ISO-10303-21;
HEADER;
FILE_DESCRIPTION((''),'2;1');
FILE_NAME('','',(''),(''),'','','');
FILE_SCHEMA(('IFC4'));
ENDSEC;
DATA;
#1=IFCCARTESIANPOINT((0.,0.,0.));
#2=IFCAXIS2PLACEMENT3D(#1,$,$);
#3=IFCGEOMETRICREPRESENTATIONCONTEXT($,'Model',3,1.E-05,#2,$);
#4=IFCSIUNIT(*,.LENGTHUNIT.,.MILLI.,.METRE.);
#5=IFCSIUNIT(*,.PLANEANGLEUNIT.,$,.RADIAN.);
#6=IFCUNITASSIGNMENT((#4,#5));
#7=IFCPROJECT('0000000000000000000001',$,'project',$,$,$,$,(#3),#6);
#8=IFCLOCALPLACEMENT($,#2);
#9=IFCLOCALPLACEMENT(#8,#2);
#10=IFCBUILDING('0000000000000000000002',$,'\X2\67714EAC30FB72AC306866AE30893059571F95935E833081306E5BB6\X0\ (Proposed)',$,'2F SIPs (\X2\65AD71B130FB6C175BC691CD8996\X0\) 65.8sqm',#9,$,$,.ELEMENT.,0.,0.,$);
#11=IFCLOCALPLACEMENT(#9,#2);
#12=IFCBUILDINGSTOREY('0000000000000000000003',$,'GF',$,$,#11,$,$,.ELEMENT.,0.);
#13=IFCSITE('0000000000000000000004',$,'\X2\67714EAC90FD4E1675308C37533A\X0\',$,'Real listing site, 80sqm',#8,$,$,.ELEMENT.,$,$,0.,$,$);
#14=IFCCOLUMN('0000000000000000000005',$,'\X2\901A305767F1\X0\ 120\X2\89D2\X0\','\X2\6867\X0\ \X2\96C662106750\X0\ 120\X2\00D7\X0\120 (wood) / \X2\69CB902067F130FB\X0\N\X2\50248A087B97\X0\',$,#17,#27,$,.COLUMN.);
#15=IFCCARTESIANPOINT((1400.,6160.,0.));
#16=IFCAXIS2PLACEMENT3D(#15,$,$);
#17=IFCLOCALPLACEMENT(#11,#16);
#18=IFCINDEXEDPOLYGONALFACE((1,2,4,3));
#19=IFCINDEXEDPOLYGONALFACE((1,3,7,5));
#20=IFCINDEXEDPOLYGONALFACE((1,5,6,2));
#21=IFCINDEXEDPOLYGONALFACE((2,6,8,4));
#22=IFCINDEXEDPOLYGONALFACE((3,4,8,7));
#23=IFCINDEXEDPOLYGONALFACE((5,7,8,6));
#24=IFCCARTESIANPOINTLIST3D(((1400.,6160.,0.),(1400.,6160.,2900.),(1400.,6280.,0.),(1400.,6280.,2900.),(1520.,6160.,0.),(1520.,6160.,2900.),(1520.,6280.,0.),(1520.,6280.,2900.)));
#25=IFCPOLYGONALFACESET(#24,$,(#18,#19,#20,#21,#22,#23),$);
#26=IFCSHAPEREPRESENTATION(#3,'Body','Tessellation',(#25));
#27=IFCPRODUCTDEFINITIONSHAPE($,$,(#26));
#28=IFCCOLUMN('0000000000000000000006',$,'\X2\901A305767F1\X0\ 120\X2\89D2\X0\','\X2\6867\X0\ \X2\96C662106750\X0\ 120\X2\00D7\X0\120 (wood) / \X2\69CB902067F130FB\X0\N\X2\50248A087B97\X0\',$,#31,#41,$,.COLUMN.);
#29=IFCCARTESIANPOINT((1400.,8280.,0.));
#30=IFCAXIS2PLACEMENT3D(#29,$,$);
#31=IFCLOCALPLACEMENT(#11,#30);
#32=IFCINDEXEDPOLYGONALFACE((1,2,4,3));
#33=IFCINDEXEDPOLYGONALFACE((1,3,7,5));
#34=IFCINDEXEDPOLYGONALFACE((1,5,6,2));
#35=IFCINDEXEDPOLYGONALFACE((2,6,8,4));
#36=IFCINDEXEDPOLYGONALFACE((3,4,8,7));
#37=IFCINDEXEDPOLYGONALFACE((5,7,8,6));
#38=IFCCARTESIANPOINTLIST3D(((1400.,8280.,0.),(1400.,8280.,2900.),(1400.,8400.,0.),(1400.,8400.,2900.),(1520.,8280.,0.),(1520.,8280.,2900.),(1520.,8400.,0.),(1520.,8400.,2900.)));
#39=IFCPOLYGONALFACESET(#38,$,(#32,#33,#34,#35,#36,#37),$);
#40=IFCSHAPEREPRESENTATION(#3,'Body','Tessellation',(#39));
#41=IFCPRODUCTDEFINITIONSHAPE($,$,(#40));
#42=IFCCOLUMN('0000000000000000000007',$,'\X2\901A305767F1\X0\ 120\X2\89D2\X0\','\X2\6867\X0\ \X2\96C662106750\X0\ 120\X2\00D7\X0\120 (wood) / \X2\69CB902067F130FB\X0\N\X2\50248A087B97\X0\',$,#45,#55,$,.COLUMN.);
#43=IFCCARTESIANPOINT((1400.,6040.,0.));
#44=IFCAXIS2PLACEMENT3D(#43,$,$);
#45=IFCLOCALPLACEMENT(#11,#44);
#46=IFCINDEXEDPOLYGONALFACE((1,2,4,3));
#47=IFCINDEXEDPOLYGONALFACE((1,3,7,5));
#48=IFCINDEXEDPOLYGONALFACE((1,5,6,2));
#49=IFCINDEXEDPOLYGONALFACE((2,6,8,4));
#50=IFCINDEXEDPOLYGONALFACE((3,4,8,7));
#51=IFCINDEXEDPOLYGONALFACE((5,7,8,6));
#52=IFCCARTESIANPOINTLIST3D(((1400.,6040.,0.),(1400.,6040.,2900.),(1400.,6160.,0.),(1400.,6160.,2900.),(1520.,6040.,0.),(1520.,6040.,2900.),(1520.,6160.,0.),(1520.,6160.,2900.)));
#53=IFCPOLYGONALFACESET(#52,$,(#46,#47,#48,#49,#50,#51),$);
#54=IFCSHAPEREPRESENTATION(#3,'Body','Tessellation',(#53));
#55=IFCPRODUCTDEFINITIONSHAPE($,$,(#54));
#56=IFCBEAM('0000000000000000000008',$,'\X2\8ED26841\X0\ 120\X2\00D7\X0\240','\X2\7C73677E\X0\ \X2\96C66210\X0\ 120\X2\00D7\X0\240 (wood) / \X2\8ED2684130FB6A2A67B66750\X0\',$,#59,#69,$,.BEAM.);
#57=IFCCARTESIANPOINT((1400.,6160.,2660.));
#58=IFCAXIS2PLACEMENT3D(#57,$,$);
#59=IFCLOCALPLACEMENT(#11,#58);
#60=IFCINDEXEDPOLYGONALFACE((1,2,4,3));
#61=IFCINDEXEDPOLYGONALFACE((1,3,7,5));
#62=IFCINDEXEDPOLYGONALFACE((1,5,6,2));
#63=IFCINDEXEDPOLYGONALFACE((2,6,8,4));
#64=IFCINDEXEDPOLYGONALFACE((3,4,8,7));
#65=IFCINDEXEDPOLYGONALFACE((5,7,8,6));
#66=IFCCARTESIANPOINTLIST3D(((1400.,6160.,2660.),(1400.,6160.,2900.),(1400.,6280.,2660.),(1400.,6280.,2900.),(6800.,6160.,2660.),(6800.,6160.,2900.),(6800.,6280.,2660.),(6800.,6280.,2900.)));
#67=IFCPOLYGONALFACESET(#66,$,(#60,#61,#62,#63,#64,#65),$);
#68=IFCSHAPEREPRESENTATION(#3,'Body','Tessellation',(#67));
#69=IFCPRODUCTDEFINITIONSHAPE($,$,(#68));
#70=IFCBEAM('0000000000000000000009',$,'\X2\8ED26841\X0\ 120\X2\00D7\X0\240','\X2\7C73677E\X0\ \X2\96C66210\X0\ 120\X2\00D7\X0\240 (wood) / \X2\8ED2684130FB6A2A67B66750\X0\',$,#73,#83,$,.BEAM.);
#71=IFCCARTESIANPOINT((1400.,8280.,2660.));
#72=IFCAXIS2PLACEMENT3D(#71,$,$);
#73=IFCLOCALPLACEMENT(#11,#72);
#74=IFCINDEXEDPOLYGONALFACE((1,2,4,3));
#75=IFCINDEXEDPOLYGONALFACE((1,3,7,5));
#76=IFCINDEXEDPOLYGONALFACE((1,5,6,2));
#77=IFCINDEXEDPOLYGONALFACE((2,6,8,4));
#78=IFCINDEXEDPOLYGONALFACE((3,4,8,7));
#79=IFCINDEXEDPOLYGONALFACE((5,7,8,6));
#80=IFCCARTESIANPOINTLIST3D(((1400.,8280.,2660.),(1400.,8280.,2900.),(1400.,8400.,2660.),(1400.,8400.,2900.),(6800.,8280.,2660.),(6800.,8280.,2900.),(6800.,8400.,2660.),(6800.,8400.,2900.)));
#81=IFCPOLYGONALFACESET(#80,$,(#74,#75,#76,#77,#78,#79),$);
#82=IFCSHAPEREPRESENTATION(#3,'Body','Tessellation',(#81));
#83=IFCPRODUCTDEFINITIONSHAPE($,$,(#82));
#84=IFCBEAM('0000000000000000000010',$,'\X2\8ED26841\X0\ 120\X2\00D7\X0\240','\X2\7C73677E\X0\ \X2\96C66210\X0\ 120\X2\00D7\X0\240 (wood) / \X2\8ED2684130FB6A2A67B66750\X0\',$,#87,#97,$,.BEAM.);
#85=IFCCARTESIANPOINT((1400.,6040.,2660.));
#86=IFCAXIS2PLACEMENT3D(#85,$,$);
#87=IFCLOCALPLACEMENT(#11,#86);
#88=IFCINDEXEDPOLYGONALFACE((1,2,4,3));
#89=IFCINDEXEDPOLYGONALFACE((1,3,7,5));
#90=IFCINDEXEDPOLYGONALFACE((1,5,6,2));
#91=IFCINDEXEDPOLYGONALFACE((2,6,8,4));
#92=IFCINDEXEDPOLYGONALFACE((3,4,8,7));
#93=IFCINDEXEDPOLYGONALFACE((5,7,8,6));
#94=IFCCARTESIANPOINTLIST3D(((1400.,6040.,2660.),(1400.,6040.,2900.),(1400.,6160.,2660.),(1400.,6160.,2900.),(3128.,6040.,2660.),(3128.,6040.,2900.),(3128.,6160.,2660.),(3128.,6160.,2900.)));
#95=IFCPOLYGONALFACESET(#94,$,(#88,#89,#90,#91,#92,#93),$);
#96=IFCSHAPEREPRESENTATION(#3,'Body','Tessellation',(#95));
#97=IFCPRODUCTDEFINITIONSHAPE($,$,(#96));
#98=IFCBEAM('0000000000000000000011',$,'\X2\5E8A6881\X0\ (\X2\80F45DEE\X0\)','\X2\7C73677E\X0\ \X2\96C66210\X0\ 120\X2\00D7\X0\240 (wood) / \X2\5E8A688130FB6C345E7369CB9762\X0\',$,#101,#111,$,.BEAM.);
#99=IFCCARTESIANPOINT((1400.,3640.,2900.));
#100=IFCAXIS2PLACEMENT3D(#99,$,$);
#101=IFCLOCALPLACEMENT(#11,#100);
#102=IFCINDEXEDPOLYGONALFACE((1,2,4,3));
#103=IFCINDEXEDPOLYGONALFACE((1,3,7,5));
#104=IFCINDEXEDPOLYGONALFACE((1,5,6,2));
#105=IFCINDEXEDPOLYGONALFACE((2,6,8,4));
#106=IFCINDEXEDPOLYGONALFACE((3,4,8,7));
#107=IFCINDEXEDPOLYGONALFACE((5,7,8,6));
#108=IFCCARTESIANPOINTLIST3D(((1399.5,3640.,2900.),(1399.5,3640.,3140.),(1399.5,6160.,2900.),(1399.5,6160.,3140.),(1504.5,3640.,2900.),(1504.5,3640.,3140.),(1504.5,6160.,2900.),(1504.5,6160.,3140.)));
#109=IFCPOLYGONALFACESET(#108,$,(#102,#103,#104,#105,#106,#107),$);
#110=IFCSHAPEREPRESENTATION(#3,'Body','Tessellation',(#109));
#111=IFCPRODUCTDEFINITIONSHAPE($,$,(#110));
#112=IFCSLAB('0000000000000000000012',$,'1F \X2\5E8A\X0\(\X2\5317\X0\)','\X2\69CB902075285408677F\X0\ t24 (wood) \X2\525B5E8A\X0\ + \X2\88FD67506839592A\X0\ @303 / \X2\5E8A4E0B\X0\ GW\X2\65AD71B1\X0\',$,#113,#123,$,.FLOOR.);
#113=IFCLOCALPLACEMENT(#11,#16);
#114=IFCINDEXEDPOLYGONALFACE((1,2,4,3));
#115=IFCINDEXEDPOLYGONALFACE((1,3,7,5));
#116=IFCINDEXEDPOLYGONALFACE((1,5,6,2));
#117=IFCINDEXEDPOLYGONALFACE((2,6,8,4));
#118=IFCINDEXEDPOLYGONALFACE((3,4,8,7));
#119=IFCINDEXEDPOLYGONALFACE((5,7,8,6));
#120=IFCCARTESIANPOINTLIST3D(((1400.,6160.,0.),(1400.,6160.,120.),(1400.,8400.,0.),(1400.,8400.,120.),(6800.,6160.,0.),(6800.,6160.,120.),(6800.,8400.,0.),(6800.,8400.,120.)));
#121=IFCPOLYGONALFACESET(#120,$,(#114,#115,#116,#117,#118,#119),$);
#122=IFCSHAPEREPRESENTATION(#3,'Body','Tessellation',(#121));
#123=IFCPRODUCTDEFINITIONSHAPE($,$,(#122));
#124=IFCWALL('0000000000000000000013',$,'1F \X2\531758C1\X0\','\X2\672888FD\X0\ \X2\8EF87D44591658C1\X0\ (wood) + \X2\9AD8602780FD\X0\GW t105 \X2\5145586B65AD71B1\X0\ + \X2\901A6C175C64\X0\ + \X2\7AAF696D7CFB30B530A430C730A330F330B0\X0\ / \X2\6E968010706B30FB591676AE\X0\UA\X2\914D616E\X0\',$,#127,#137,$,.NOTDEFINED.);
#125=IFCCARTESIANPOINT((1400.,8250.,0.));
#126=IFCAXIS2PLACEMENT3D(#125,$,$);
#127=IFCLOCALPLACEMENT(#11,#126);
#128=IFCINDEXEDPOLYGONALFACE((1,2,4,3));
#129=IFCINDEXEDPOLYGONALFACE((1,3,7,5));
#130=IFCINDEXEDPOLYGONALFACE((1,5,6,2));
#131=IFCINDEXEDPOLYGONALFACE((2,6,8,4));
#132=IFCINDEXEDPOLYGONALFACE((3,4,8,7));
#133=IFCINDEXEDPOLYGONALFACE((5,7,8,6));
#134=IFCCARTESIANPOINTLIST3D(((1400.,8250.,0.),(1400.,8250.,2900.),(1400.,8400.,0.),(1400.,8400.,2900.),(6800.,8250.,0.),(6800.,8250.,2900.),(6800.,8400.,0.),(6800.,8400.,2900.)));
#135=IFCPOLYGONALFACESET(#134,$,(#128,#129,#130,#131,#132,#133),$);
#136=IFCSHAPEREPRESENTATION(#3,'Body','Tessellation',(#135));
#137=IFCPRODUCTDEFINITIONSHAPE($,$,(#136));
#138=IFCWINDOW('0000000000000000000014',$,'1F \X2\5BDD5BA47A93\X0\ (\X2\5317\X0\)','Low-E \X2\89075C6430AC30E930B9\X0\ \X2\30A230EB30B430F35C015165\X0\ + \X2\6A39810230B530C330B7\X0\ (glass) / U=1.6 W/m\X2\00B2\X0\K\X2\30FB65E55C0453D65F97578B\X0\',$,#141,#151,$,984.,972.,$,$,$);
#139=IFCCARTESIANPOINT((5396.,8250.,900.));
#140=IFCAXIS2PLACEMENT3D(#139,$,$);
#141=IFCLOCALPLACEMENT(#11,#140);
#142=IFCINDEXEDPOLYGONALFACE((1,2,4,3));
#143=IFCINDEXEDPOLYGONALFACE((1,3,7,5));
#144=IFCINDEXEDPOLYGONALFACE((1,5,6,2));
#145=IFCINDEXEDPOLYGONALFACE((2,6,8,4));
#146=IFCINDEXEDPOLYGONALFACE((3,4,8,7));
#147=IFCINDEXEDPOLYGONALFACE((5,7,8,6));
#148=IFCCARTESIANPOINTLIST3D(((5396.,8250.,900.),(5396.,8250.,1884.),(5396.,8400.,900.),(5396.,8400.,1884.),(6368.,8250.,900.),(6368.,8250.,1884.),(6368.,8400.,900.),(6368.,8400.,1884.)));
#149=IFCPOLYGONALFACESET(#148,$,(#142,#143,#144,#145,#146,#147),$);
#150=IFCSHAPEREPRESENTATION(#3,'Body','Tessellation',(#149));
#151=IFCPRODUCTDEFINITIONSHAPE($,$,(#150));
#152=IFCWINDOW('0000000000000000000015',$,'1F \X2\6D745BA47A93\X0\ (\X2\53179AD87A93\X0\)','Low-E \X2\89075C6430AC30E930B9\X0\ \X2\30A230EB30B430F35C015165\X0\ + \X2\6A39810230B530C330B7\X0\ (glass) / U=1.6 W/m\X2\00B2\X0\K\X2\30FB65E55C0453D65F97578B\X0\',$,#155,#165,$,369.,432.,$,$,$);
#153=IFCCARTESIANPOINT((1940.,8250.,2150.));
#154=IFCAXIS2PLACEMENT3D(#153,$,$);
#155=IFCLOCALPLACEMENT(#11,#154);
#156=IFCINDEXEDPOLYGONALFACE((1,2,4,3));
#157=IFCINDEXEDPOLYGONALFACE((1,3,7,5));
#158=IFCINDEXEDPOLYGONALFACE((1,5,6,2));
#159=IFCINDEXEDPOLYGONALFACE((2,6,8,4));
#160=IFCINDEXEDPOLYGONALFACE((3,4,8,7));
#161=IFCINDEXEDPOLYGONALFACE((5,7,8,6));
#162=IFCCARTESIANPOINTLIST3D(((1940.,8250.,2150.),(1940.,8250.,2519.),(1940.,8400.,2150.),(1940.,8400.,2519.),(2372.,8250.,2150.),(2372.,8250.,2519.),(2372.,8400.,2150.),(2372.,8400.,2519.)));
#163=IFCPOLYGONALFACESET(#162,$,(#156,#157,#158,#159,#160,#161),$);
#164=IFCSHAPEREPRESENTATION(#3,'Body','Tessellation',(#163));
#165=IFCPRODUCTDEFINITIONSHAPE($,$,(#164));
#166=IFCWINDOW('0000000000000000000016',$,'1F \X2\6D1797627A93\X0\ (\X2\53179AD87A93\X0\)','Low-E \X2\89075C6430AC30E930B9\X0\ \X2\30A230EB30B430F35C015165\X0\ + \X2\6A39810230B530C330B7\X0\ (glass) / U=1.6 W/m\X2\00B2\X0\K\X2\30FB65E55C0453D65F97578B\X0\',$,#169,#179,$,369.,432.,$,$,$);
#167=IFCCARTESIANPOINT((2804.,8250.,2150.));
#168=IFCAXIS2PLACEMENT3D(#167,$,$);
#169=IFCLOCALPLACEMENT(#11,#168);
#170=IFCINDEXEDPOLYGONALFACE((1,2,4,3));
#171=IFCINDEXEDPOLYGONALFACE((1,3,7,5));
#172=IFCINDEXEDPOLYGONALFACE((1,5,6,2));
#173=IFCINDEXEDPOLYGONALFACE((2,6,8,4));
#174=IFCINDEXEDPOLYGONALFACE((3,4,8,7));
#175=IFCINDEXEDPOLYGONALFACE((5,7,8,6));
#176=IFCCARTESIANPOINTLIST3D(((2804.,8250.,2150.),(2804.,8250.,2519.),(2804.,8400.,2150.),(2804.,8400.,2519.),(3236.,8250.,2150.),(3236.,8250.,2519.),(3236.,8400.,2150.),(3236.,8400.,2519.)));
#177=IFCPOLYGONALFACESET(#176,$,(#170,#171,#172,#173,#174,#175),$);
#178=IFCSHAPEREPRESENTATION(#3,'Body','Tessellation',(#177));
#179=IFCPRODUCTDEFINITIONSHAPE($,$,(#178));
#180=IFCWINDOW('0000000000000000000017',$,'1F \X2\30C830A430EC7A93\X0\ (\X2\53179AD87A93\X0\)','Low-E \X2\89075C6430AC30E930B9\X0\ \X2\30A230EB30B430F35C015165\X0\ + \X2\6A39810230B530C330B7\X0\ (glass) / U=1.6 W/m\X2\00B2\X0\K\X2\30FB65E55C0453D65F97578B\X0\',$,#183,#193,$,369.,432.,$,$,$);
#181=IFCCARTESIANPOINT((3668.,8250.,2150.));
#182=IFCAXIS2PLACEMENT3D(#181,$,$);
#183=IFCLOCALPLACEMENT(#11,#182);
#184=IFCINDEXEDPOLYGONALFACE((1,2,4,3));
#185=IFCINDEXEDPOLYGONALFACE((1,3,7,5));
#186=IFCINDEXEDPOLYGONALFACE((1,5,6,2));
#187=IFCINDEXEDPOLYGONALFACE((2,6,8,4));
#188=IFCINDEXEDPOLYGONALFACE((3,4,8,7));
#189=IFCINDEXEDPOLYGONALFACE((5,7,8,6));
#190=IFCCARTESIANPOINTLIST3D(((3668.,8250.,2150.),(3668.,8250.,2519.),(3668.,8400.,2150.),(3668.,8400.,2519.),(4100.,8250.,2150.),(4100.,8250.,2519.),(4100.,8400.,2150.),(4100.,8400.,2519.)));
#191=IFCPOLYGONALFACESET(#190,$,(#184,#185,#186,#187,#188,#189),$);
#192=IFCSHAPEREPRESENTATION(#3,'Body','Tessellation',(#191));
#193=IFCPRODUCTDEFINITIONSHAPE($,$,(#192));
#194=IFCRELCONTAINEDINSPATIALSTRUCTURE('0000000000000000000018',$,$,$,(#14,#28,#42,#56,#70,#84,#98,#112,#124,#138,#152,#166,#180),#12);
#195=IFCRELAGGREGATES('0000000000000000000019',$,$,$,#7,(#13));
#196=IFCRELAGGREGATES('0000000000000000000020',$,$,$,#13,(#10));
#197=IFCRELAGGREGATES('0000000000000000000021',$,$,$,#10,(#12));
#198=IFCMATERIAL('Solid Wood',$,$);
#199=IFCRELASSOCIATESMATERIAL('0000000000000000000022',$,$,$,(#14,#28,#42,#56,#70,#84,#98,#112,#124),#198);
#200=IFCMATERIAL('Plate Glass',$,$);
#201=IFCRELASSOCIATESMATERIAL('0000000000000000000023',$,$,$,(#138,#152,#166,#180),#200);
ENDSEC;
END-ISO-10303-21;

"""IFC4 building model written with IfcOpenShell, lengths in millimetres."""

from ifc_helpers import new_model, si_unit, frame, frame_2d, origin, place, context, project, spatial, rectangle, extrude, material, element, fill, save


model = new_model("IFC4")

# Units and contexts
model_context = context("Model", 3, precision=1e-05, world=origin())
ifc_project = project(units=[si_unit("LENGTHUNIT", "METRE", prefix="MILLI"), si_unit("PLANEANGLEUNIT", "RADIAN")], contexts=[model_context])

# Site, building, storey
site_placement = place(None, origin())
site = spatial("IfcSite", under=ifc_project, at=site_placement, Name="東京都世田谷区", ObjectType="Real listing site, 80sqm", CompositionType="ELEMENT", RefElevation=0.0)
building_placement = place(site_placement, origin())
building = spatial("IfcBuilding", under=site, at=building_placement, Name="東京・犬と暮らす土間広めの家 (Proposed)", ObjectType="2F SIPs (断熱・気密重視) 65.8sqm", CompositionType="ELEMENT", ElevationOfRefHeight=0.0, ElevationOfTerrain=0.0)
storey_placement = place(building_placement, origin())
storey = spatial("IfcBuildingStorey", under=building, at=storey_placement, Name="GF", CompositionType="ELEMENT", Elevation=0.0)

# Columns
ifc_material_1 = material(Name="Solid Wood")
column_1_placement = place(storey_placement, frame((1400.0, 6160.0, 0.0)))
element("IfcColumn", 1, at=column_1_placement, inside=storey, material=ifc_material_1, Name="通し柱 120角", Description="桧 集成材 120×120 (wood) / 構造柱・N値計算", PredefinedType="COLUMN", context=model_context, shape_type="SweptSolid", body=[
    extrude(rectangle(XDim=120.0, YDim=120.0, at=frame_2d((60.0, 60.0))), frame((1400.0, 6160.0, 0.0)), (0.0, 0.0, 1.0), 2900.0),
])
column_2_placement = place(storey_placement, frame((1400.0, 8280.0, 0.0)))
element("IfcColumn", 2, at=column_2_placement, inside=storey, material=ifc_material_1, Name="通し柱 120角", Description="桧 集成材 120×120 (wood) / 構造柱・N値計算", PredefinedType="COLUMN", context=model_context, shape_type="SweptSolid", body=[
    extrude(rectangle(XDim=120.0, YDim=120.0, at=frame_2d((60.0, 60.0))), frame((1400.0, 8280.0, 0.0)), (0.0, 0.0, 1.0), 2900.0),
])
column_3_placement = place(storey_placement, frame((1400.0, 6040.0, 0.0)))
element("IfcColumn", 3, at=column_3_placement, inside=storey, material=ifc_material_1, Name="通し柱 120角", Description="桧 集成材 120×120 (wood) / 構造柱・N値計算", PredefinedType="COLUMN", context=model_context, shape_type="SweptSolid", body=[
    extrude(rectangle(XDim=120.0, YDim=120.0, at=frame_2d((60.0, 60.0))), frame((1400.0, 6040.0, 0.0)), (0.0, 0.0, 1.0), 2900.0),
])

# Beams
beam_1_placement = place(storey_placement, frame((1400.0, 6160.0, 2660.0)))
element("IfcBeam", 4, at=beam_1_placement, inside=storey, material=ifc_material_1, Name="軒桁 120×240", Description="米松 集成 120×240 (wood) / 軒桁・横架材", PredefinedType="BEAM", context=model_context, shape_type="SweptSolid", body=[
    extrude(rectangle(XDim=5400.0, YDim=120.0, at=frame_2d((2700.0, 60.0))), frame((1400.0, 6160.0, 2660.0)), (0.0, 0.0, 1.0), 240.0),
])
beam_2_placement = place(storey_placement, frame((1400.0, 8280.0, 2660.0)))
element("IfcBeam", 5, at=beam_2_placement, inside=storey, material=ifc_material_1, Name="軒桁 120×240", Description="米松 集成 120×240 (wood) / 軒桁・横架材", PredefinedType="BEAM", context=model_context, shape_type="SweptSolid", body=[
    extrude(rectangle(XDim=5400.0, YDim=120.0, at=frame_2d((2700.0, 60.0))), frame((1400.0, 8280.0, 2660.0)), (0.0, 0.0, 1.0), 240.0),
])
beam_3_placement = place(storey_placement, frame((1400.0, 6040.0, 2660.0)))
element("IfcBeam", 6, at=beam_3_placement, inside=storey, material=ifc_material_1, Name="軒桁 120×240", Description="米松 集成 120×240 (wood) / 軒桁・横架材", PredefinedType="BEAM", context=model_context, shape_type="SweptSolid", body=[
    extrude(rectangle(XDim=1728.0, YDim=120.0, at=frame_2d((864.0, 60.0))), frame((1400.0, 6040.0, 2660.0)), (0.0, 0.0, 1.0), 240.0),
])
beam_4_placement = place(storey_placement, frame((1400.0, 3640.0, 2900.0)))
element("IfcBeam", 7, at=beam_4_placement, inside=storey, material=ifc_material_1, Name="床梁 (胴差)", Description="米松 集成 120×240 (wood) / 床梁・水平構面", PredefinedType="BEAM", context=model_context, shape_type="SweptSolid", body=[
    extrude(rectangle(XDim=105.0, YDim=2520.0, at=frame_2d((52.0, 1260.0))), frame((1400.0, 3640.0, 2900.0)), (0.0, 0.0, 1.0), 240.0),
])

# Slab
slab_placement = place(storey_placement, frame((1400.0, 6160.0, 0.0)))
element("IfcSlab", 8, at=slab_placement, inside=storey, material=ifc_material_1, Name="1F 床(北)", Description="構造用合板 t24 (wood) 剛床 + 製材根太 @303 / 床下 GW断熱", PredefinedType="FLOOR", context=model_context, shape_type="SweptSolid", body=[
    extrude(rectangle(XDim=5400.0, YDim=2240.0, at=frame_2d((2700.0, 1120.0))), frame((1400.0, 6160.0, 0.0)), (0.0, 0.0, 1.0), 120.0),
])

# Wall, openings, windows
wall_1_placement = place(storey_placement, frame((1400.0, 8250.0, 0.0)))
wall_1 = element("IfcWall", 9, at=wall_1_placement, inside=storey, material=ifc_material_1, Name="1F 北壁", Description="木製 軸組外壁 (wood) + 高性能GW t105 充填断熱 + 通気層 + 窯業系サイディング / 準耐火・外皮UA配慮", PredefinedType="NOTDEFINED", context=model_context, shape_type="SweptSolid", body=[
    extrude(rectangle(XDim=5400.0, YDim=150.0, at=frame_2d((2700.0, 75.0))), frame((1400.0, 8250.0, 0.0)), (0.0, 0.0, 1.0), 2900.0),
])
opening_1_placement = place(storey_placement, frame((5396.0, 8250.0, 900.0)))
opening_1 = element("IfcOpeningElement", 10, at=opening_1_placement, cuts=wall_1, PredefinedType="NOTDEFINED", context=model_context, shape_type="SweptSolid", body=[
    extrude(rectangle(XDim=972.0, YDim=150.0, at=frame_2d((486.0, 75.0))), frame((5396.0, 8250.0, 900.0)), (0.0, 0.0, 1.0), 984.0),
])
opening_2_placement = place(storey_placement, frame((1940.0, 8250.0, 2150.0)))
opening_2 = element("IfcOpeningElement", 11, at=opening_2_placement, cuts=wall_1, PredefinedType="NOTDEFINED", context=model_context, shape_type="SweptSolid", body=[
    extrude(rectangle(XDim=432.0, YDim=150.0, at=frame_2d((216.0, 75.0))), frame((1940.0, 8250.0, 2150.0)), (0.0, 0.0, 1.0), 369.0),
])
opening_3_placement = place(storey_placement, frame((2804.0, 8250.0, 2150.0)))
opening_3 = element("IfcOpeningElement", 12, at=opening_3_placement, cuts=wall_1, PredefinedType="NOTDEFINED", context=model_context, shape_type="SweptSolid", body=[
    extrude(rectangle(XDim=432.0, YDim=150.0, at=frame_2d((216.0, 75.0))), frame((2804.0, 8250.0, 2150.0)), (0.0, 0.0, 1.0), 369.0),
])
opening_4_placement = place(storey_placement, frame((3668.0, 8250.0, 2150.0)))
opening_4 = element("IfcOpeningElement", 13, at=opening_4_placement, cuts=wall_1, PredefinedType="NOTDEFINED", context=model_context, shape_type="SweptSolid", body=[
    extrude(rectangle(XDim=432.0, YDim=150.0, at=frame_2d((216.0, 75.0))), frame((3668.0, 8250.0, 2150.0)), (0.0, 0.0, 1.0), 369.0),
])
ifc_material_2 = material(Name="Plate Glass")
window_1_placement = place(storey_placement, frame((5396.0, 8250.0, 900.0)))
window_1 = element("IfcWindow", 14, at=window_1_placement, inside=storey, material=ifc_material_2, Name="1F 寝室窓 (北)", Description="Low-E 複層ガラス アルゴン封入 + 樹脂サッシ (glass) / U=1.6 W/m²K・日射取得型", OverallHeight=984.0, OverallWidth=972.0, context=model_context, shape_type="SweptSolid", body=[
    extrude(rectangle(XDim=972.0, YDim=150.0, at=frame_2d((486.0, 75.0))), frame((5396.0, 8250.0, 900.0)), (0.0, 0.0, 1.0), 984.0),
])
fill(opening_1, window_1)
window_2_placement = place(storey_placement, frame((1940.0, 8250.0, 2150.0)))
window_2 = element("IfcWindow", 15, at=window_2_placement, inside=storey, material=ifc_material_2, Name="1F 浴室窓 (北高窓)", Description="Low-E 複層ガラス アルゴン封入 + 樹脂サッシ (glass) / U=1.6 W/m²K・日射取得型", OverallHeight=369.0, OverallWidth=432.0, context=model_context, shape_type="SweptSolid", body=[
    extrude(rectangle(XDim=432.0, YDim=150.0, at=frame_2d((216.0, 75.0))), frame((1940.0, 8250.0, 2150.0)), (0.0, 0.0, 1.0), 369.0),
])
fill(opening_2, window_2)
window_3_placement = place(storey_placement, frame((2804.0, 8250.0, 2150.0)))
window_3 = element("IfcWindow", 16, at=window_3_placement, inside=storey, material=ifc_material_2, Name="1F 洗面窓 (北高窓)", Description="Low-E 複層ガラス アルゴン封入 + 樹脂サッシ (glass) / U=1.6 W/m²K・日射取得型", OverallHeight=369.0, OverallWidth=432.0, context=model_context, shape_type="SweptSolid", body=[
    extrude(rectangle(XDim=432.0, YDim=150.0, at=frame_2d((216.0, 75.0))), frame((2804.0, 8250.0, 2150.0)), (0.0, 0.0, 1.0), 369.0),
])
fill(opening_3, window_3)
window_4_placement = place(storey_placement, frame((3668.0, 8250.0, 2150.0)))
window_4 = element("IfcWindow", 17, at=window_4_placement, inside=storey, material=ifc_material_2, Name="1F トイレ窓 (北高窓)", Description="Low-E 複層ガラス アルゴン封入 + 樹脂サッシ (glass) / U=1.6 W/m²K・日射取得型", OverallHeight=369.0, OverallWidth=432.0, context=model_context, shape_type="SweptSolid", body=[
    extrude(rectangle(XDim=432.0, YDim=150.0, at=frame_2d((216.0, 75.0))), frame((3668.0, 8250.0, 2150.0)), (0.0, 0.0, 1.0), 369.0),
])
fill(opening_4, window_4)

save(model, "model.ifc")
